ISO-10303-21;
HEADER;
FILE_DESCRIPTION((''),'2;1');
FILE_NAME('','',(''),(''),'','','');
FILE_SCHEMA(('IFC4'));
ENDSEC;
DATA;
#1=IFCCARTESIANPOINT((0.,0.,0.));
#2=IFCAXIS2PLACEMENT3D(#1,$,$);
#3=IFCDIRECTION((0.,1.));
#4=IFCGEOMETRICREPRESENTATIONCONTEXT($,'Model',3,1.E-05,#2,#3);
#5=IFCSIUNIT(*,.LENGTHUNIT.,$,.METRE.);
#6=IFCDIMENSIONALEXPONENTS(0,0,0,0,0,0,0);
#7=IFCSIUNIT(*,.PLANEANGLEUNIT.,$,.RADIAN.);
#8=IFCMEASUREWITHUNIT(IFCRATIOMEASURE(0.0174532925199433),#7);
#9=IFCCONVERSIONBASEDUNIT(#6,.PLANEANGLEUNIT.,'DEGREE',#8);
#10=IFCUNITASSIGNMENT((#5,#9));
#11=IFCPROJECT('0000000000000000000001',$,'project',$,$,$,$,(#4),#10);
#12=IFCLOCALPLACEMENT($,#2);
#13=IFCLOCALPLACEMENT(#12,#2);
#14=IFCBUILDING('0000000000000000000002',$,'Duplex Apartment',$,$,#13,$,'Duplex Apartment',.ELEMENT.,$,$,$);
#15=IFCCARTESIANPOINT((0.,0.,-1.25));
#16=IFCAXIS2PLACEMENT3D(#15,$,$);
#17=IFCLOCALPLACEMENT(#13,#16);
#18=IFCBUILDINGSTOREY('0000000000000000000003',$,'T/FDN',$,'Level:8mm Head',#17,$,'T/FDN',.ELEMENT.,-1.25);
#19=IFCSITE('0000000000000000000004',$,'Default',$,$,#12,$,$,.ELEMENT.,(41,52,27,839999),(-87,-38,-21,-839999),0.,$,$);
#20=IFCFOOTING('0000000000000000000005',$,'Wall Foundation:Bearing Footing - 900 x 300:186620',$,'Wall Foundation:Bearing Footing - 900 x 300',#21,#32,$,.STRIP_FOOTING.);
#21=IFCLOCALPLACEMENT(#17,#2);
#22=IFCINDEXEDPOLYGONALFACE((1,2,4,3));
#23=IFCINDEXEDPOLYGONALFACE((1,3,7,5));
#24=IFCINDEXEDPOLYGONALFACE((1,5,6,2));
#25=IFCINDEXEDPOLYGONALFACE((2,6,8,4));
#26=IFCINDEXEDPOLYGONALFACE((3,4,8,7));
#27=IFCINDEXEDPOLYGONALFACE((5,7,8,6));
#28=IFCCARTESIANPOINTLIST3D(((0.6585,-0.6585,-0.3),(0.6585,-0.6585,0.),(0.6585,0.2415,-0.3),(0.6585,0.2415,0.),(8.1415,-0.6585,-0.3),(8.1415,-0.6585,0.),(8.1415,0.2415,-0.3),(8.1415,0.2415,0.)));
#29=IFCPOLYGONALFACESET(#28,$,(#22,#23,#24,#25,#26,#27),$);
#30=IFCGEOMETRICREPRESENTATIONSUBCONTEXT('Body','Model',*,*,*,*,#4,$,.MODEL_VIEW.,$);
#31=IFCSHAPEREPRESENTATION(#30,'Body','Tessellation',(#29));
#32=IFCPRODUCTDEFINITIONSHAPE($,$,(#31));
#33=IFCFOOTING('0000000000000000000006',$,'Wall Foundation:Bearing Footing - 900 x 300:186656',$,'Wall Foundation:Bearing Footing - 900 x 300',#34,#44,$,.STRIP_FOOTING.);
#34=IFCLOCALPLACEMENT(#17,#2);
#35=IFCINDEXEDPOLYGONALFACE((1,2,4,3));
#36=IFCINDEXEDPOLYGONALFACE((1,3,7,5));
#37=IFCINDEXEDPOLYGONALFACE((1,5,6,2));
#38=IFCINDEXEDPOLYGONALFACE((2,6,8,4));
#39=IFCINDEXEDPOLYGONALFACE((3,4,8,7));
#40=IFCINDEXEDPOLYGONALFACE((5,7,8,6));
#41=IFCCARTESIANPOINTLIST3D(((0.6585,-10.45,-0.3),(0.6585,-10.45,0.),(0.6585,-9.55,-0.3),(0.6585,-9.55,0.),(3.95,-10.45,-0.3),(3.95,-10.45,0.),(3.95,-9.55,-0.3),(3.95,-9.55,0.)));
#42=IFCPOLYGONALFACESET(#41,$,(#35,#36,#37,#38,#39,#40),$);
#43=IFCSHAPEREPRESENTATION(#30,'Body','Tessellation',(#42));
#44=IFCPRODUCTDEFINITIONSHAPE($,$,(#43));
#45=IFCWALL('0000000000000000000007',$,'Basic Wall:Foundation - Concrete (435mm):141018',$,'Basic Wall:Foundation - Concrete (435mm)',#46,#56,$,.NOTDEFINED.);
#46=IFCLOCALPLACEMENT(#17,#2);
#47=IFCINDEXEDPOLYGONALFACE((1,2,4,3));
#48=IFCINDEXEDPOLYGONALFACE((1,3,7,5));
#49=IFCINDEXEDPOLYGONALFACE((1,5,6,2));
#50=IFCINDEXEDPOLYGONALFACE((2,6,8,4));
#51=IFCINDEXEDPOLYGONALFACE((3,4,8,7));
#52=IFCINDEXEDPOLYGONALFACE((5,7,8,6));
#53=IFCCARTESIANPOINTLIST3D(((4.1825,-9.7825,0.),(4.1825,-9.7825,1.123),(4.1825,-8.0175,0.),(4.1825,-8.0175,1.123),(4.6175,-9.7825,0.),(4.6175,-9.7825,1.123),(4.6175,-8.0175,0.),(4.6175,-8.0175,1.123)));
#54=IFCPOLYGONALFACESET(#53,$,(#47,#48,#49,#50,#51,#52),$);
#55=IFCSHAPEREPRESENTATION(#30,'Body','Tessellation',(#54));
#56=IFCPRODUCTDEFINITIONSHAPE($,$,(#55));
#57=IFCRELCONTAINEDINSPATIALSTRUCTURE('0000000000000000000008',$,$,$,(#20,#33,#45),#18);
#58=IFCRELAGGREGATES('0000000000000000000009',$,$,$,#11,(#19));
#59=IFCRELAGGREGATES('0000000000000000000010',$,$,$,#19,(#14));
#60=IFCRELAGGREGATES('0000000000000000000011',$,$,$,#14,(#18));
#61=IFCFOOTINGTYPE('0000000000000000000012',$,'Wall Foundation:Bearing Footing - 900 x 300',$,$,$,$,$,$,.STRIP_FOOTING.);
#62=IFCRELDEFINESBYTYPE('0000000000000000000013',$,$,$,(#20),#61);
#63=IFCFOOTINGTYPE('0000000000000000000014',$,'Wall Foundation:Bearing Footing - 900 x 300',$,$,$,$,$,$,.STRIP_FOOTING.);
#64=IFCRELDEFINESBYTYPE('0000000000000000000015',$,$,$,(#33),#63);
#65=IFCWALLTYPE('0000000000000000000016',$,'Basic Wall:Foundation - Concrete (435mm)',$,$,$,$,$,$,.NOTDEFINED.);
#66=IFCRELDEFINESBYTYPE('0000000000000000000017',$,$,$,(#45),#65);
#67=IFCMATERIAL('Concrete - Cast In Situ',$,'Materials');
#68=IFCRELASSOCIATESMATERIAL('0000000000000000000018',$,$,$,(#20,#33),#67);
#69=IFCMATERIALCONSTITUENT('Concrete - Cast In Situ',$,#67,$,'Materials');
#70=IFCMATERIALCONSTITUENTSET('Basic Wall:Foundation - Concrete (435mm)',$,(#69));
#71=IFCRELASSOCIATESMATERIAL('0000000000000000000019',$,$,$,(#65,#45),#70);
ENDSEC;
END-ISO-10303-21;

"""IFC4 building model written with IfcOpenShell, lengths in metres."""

from ifc_helpers import new_model, entity, si_unit, converted_unit, direction, frame, origin, place, context, subcontext, project, spatial, indexed_curve, outline, extrude, material, constituent, constituent_set, type_object, element, save


model = new_model("IFC4")

# Units and contexts
model_context = context("Model", 3, precision=1e-05, world=origin(), true_north=direction((0.0, 1.0)))
body_context = subcontext(model_context, "Body", "Model", "MODEL_VIEW")
ifc_project = project(units=[si_unit("LENGTHUNIT", "METRE"), converted_unit("PLANEANGLEUNIT", "DEGREE", entity("IfcRatioMeasure", 0.0174532925199433), si_unit("PLANEANGLEUNIT", "RADIAN"), dimensions=[0, 0, 0, 0, 0, 0, 0])], contexts=[model_context])

# Site, building, storey
site_placement = place(None, origin())
site = spatial("IfcSite", under=ifc_project, at=site_placement, Name="Default", CompositionType="ELEMENT", RefLatitude=(41, 52, 27, 839999), RefLongitude=(-87, -38, -21, -839999), RefElevation=0.0)
building_placement = place(site_placement, origin())
building = spatial("IfcBuilding", under=site, at=building_placement, Name="Duplex Apartment", LongName="Duplex Apartment", CompositionType="ELEMENT")
storey_placement = place(building_placement, frame((0.0, 0.0, -1.25)))
storey = spatial("IfcBuildingStorey", under=building, at=storey_placement, Name="T/FDN", ObjectType="Level:8mm Head", LongName="T/FDN", CompositionType="ELEMENT", Elevation=-1.25)

# Footings
ifc_material = material(Name="Concrete - Cast In Situ", Category="Materials")
footing_type_1 = type_object("IfcFootingType", Name="Wall Foundation:Bearing Footing - 900 x 300", PredefinedType="STRIP_FOOTING")
footing_1_placement = place(storey_placement, origin())
element("IfcFooting", 1, at=footing_1_placement, inside=storey, type_object=footing_type_1, material=ifc_material, Name="Wall Foundation:Bearing Footing - 900 x 300:186620", ObjectType="Wall Foundation:Bearing Footing - 900 x 300", PredefinedType="STRIP_FOOTING", context=body_context, shape_type="SweptSolid", body=[
    extrude(outline(indexed_curve([(-3.7415, -0.45), (3.7415, -0.45), (3.7415, 0.45), (-3.7415, 0.45), (-3.7415, -0.45)], self_intersect=False)), frame((4.4, -0.2085, -0.3), z_axis=(0.0, 0.0, 1.0), x_axis=(-1.0, 0.0, 0.0)), (0.0, 0.0, 1.0), 0.3),
])
footing_type_2 = type_object("IfcFootingType", Name="Wall Foundation:Bearing Footing - 900 x 300", PredefinedType="STRIP_FOOTING")
footing_2_placement = place(storey_placement, origin())
element("IfcFooting", 2, at=footing_2_placement, inside=storey, type_object=footing_type_2, material=ifc_material, Name="Wall Foundation:Bearing Footing - 900 x 300:186656", ObjectType="Wall Foundation:Bearing Footing - 900 x 300", PredefinedType="STRIP_FOOTING", context=body_context, shape_type="SweptSolid", body=[
    extrude(outline(indexed_curve([(-1.6457, -0.45), (1.6458, -0.45), (1.6458, 0.45), (-1.6458, 0.45), (-1.6457, -0.45)], self_intersect=False)), frame((2.3043, -10.0, -0.3)), (0.0, 0.0, 1.0), 0.3),
])

# Wall
ifc_constituent_1 = constituent(ifc_material, Name="Concrete - Cast In Situ", Category="Materials")
ifc_constituent_set_1 = constituent_set(constituents=[ifc_constituent_1], Name="Basic Wall:Foundation - Concrete (435mm)")
wall_type_1 = type_object("IfcWallType", Name="Basic Wall:Foundation - Concrete (435mm)", PredefinedType="NOTDEFINED", material=ifc_constituent_set_1)
wall_1_placement = place(storey_placement, frame((4.4, -9.7825, 0.0), z_axis=(0.0, 0.0, 1.0), x_axis=(0.0, 1.0, 0.0)))
element("IfcWall", 3, at=wall_1_placement, inside=storey, type_object=wall_type_1, material=ifc_constituent_set_1, Name="Basic Wall:Foundation - Concrete (435mm):141018", ObjectType="Basic Wall:Foundation - Concrete (435mm)", PredefinedType="NOTDEFINED", context=body_context, shape_type="SweptSolid", body=[
    extrude(outline(indexed_curve([(-0.2175, -0.8825), (0.2175, -0.8825), (0.2175, 0.8825), (-0.2175, 0.8825), (-0.2175, -0.8825)], self_intersect=False)), frame((0.8825, 0.0, 0.0), z_axis=(0.0, 0.0, 1.0), x_axis=(0.0, 1.0, 0.0)), (0.0, 0.0, 1.0), 1.123),
])

save(model, "model.ifc")
